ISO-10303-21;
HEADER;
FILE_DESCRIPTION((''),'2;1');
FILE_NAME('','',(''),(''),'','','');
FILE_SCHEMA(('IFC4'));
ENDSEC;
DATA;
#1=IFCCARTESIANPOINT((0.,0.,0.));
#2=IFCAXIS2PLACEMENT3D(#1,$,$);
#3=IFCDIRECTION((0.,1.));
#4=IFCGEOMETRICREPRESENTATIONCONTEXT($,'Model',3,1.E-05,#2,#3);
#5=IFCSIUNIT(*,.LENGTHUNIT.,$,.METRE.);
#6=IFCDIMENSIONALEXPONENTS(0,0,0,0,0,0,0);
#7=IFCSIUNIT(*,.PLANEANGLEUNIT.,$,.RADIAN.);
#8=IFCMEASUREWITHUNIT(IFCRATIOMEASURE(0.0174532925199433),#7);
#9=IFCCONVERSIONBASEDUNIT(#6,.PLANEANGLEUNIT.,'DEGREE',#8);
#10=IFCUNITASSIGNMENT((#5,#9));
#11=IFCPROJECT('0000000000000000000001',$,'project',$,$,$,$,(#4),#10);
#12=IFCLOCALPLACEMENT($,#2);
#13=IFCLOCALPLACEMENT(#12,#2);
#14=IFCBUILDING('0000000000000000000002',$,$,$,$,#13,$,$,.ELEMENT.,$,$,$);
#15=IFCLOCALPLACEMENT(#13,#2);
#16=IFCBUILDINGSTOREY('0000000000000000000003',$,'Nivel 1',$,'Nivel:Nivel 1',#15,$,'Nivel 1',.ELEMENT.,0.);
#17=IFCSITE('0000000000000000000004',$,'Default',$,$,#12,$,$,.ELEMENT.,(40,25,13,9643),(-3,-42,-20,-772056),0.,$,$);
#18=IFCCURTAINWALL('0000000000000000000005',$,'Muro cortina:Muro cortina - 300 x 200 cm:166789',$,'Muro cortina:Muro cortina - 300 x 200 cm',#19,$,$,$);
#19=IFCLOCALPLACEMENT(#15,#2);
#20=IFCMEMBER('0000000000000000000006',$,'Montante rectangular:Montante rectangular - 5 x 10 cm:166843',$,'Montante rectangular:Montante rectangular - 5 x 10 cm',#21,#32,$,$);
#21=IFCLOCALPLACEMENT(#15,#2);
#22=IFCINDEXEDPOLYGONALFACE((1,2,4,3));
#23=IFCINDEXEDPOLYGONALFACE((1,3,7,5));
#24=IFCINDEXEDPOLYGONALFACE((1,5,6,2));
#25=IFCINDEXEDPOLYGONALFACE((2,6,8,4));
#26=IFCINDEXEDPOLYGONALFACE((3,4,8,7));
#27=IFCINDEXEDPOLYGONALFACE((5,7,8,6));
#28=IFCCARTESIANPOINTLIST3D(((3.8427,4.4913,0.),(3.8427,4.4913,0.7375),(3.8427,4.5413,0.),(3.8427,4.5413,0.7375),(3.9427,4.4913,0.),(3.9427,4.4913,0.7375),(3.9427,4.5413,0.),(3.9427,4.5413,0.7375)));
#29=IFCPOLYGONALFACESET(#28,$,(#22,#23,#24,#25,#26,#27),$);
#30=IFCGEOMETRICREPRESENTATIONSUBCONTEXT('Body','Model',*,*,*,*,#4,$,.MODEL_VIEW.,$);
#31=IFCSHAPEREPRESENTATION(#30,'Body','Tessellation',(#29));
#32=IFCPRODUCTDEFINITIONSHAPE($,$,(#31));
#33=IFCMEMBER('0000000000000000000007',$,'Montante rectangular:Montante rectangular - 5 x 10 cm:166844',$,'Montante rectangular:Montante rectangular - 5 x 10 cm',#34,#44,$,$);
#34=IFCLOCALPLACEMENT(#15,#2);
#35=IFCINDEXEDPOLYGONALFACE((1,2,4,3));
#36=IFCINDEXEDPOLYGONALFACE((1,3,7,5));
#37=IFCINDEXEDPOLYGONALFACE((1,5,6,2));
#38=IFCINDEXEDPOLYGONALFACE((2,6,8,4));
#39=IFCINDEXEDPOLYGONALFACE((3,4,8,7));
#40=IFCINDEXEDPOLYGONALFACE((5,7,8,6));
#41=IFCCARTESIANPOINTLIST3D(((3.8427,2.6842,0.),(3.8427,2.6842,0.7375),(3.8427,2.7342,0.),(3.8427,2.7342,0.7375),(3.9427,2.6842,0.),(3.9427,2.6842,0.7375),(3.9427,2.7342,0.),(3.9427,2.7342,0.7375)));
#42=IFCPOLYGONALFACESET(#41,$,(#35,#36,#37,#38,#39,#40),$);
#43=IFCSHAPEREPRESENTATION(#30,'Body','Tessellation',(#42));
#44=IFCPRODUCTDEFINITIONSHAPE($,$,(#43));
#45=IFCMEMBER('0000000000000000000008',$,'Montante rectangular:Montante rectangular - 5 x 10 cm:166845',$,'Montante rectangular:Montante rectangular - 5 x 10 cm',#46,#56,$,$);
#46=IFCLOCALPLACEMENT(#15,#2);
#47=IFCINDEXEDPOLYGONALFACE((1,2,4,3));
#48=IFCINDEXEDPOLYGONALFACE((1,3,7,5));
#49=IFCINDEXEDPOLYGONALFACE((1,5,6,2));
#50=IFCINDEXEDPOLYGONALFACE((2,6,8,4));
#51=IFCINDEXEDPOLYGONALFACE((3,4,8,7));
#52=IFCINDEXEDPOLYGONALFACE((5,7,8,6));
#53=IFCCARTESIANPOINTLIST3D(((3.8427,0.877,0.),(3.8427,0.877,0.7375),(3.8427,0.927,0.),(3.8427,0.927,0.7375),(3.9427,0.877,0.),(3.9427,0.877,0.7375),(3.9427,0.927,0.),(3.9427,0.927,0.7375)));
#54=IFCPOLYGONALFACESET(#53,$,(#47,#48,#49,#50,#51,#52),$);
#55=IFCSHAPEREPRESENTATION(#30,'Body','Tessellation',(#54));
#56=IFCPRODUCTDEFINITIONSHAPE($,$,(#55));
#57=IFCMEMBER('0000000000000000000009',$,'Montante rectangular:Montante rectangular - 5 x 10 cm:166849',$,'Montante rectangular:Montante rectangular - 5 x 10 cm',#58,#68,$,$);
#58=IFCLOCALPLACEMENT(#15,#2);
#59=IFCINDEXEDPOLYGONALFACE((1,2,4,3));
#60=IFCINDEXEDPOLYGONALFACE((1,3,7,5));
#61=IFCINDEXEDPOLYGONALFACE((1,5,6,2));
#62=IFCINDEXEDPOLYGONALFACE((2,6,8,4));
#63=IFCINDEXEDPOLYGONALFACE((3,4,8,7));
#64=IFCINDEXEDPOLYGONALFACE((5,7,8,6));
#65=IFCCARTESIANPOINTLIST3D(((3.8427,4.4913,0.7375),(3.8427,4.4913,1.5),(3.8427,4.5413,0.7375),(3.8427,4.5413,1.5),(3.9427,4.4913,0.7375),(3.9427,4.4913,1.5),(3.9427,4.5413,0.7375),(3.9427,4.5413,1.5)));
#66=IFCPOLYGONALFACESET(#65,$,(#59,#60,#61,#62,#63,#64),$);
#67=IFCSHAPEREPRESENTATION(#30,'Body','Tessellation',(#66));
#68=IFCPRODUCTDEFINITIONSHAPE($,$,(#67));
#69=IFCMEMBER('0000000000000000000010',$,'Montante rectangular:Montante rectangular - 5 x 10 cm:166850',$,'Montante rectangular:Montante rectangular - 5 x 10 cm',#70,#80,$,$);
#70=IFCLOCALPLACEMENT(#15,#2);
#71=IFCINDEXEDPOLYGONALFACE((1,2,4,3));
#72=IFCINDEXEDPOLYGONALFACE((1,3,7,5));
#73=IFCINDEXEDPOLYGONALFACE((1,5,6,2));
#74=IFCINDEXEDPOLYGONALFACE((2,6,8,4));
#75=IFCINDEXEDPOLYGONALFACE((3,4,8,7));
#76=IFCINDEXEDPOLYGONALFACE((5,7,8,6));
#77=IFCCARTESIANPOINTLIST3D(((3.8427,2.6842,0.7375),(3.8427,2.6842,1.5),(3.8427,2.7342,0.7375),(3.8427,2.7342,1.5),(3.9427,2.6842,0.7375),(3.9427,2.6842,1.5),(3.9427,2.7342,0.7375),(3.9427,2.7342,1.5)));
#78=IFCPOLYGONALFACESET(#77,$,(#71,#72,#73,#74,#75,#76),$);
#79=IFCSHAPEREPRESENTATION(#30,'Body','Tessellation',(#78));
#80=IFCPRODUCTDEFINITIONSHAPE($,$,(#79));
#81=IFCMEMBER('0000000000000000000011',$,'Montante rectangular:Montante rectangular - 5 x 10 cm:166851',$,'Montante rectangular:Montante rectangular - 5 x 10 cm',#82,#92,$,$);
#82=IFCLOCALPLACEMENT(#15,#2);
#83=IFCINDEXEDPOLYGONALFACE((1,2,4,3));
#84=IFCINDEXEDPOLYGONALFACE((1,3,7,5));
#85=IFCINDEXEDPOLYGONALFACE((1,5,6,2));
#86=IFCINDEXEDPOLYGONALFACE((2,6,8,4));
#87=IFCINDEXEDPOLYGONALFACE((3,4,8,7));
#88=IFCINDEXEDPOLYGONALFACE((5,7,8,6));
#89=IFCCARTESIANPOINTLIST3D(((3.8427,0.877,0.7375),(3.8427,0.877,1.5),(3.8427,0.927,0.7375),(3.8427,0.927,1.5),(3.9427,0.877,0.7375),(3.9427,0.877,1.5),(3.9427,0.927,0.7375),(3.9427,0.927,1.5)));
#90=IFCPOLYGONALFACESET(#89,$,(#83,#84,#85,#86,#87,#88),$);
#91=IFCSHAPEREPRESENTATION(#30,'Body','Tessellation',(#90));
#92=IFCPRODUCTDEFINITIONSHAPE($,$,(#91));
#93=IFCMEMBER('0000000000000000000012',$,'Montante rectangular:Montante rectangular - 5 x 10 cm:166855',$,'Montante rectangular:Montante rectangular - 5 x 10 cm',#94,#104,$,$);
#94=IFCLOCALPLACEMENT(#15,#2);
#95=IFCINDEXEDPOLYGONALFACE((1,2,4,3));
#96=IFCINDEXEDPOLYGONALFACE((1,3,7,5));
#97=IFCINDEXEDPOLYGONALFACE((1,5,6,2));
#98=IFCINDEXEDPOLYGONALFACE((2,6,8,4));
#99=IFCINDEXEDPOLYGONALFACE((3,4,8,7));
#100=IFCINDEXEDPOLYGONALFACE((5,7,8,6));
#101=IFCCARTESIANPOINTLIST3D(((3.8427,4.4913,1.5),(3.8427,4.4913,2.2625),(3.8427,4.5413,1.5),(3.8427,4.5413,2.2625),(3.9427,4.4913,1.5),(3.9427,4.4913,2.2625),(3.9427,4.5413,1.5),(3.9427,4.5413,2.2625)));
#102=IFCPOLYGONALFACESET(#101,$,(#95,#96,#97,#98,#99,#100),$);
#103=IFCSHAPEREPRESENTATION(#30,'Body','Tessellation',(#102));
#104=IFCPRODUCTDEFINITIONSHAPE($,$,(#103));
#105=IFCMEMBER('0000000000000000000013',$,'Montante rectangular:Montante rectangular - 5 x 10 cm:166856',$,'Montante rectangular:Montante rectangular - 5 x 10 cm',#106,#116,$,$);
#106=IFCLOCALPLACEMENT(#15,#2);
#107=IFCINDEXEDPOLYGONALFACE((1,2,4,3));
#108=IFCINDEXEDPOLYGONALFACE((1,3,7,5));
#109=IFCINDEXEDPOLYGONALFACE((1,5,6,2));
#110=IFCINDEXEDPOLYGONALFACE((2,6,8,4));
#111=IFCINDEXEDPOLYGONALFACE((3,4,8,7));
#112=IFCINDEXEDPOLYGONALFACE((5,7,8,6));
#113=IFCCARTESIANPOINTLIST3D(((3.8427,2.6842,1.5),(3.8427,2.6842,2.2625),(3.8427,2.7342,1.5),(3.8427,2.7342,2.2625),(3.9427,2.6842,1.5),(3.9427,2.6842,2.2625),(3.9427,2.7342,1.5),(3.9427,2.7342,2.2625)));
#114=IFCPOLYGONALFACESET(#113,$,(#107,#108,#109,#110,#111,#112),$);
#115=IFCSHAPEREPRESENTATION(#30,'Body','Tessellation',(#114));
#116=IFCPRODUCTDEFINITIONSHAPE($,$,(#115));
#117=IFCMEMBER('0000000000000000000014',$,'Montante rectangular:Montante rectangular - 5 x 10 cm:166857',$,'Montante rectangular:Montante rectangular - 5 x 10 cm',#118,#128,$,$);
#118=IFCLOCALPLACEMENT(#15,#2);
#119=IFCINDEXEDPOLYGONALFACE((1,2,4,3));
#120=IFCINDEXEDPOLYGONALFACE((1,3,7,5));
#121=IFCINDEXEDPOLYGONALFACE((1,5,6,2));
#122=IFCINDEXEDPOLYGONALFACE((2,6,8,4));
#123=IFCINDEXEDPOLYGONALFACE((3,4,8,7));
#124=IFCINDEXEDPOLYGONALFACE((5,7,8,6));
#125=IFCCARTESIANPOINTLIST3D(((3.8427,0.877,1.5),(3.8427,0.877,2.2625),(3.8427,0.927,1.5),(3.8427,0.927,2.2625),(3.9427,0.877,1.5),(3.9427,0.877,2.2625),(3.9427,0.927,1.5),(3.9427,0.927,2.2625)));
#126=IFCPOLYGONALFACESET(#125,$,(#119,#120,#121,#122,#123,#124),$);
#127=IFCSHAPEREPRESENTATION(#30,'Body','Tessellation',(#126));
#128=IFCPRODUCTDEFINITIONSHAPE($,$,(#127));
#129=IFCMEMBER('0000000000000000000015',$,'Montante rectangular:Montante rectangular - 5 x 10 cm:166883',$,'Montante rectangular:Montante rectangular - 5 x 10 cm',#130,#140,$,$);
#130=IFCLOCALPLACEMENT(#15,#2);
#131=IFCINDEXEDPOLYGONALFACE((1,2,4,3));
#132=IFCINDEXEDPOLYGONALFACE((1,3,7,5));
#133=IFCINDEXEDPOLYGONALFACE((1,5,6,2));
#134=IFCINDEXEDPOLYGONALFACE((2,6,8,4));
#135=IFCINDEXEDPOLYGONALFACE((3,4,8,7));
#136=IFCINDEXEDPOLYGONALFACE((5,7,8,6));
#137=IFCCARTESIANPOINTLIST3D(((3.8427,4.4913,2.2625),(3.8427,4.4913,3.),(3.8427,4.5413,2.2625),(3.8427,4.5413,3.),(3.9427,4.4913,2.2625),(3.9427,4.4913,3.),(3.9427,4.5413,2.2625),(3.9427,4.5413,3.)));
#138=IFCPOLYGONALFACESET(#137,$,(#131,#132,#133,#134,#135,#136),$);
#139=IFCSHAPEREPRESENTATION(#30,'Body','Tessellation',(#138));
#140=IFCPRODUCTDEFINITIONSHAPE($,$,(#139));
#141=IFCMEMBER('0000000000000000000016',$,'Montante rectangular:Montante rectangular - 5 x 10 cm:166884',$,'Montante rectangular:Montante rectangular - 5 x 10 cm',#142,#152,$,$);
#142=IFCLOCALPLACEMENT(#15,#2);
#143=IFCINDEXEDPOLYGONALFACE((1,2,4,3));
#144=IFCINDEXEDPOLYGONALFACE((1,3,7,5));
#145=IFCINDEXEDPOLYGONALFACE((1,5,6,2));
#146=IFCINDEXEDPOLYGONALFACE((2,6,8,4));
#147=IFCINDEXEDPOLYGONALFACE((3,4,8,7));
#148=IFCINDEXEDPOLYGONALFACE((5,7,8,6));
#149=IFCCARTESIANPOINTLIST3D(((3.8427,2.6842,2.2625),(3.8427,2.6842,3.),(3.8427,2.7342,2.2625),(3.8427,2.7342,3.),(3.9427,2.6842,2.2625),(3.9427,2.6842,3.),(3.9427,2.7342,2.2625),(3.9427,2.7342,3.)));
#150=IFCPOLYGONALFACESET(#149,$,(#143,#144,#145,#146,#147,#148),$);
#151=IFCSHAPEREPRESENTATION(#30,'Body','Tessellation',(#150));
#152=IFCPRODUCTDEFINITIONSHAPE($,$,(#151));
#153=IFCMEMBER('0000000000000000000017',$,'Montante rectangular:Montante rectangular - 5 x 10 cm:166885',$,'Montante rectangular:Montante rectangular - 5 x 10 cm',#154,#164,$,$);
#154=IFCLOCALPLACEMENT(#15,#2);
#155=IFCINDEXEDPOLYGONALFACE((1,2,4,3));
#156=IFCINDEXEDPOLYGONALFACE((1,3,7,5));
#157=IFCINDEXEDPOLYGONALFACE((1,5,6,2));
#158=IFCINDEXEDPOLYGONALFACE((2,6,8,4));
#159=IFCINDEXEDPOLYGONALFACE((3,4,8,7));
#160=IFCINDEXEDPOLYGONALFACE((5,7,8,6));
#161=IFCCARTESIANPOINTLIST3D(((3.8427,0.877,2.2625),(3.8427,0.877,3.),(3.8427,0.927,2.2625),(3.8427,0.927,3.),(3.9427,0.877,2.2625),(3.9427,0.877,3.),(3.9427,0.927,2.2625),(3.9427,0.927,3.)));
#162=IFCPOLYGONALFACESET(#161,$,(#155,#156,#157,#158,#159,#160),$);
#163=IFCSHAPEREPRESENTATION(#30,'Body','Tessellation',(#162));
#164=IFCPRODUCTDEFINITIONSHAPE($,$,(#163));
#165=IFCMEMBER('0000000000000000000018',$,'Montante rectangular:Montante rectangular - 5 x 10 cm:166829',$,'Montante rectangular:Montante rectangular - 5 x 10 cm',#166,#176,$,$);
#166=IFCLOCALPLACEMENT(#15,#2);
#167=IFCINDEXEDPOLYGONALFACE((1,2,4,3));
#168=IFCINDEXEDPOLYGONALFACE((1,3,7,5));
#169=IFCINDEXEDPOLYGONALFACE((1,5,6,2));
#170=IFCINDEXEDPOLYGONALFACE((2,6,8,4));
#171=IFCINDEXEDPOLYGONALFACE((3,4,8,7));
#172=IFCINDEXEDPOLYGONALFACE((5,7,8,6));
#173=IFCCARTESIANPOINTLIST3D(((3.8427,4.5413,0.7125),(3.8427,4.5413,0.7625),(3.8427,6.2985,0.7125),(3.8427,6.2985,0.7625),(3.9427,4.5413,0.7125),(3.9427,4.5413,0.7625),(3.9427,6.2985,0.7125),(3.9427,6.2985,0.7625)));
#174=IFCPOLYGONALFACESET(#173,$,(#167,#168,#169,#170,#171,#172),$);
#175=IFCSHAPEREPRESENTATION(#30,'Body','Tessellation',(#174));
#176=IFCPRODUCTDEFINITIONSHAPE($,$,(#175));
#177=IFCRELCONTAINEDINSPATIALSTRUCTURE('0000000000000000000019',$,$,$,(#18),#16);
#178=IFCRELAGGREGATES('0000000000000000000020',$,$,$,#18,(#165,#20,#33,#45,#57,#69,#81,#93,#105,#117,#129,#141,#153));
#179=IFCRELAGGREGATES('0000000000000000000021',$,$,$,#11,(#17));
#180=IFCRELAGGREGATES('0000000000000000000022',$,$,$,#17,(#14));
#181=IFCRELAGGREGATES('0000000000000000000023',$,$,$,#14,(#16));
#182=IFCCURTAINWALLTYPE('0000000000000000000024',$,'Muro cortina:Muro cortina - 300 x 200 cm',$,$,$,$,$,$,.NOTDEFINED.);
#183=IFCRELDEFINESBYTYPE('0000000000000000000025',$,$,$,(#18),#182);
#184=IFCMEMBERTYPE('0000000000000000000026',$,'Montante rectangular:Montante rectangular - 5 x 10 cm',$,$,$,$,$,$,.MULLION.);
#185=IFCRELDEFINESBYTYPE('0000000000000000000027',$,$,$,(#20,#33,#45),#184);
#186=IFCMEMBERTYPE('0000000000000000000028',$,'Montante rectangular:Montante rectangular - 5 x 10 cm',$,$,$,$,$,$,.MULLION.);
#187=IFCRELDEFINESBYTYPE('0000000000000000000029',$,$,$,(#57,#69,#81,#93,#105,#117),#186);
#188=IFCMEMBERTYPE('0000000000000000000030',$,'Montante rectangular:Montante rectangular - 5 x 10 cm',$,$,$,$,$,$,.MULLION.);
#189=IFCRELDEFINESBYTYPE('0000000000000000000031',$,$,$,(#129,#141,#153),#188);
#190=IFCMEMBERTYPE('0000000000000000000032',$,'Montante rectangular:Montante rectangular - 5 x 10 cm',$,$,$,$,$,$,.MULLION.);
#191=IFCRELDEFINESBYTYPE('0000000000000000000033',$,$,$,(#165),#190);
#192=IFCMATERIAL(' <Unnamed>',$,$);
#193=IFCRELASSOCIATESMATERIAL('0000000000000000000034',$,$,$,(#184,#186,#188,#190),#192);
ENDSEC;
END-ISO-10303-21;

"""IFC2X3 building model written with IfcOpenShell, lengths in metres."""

from ifc_helpers import new_model, entity, si_unit, converted_unit, direction, frame, origin, origin_2d_with_axis, place, context, subcontext, project, spatial, rectangle, extrude, source, transform, mapped, material, type_object, type_shapes, element, aggregate, save


model = new_model("IFC2X3")

# Units and contexts
model_context = context("Model", 3, precision=1e-05, world=origin(), true_north=direction((0.0, 1.0)))
body_context = subcontext(model_context, "Body", "Model", "MODEL_VIEW")
ifc_project = project(units=[si_unit("LENGTHUNIT", "METRE"), converted_unit("PLANEANGLEUNIT", "DEGREE", entity("IfcRatioMeasure", 0.0174532925199433), si_unit("PLANEANGLEUNIT", "RADIAN"), dimensions=[0, 0, 0, 0, 0, 0, 0])], contexts=[model_context])

# Site, building, storey
site_placement = place(None, origin())
site = spatial("IfcSite", under=ifc_project, at=site_placement, Name="Default", CompositionType="ELEMENT", RefLatitude=(40, 25, 13, 9643), RefLongitude=(-3, -42, -20, -772056), RefElevation=0.0)
building_placement = place(site_placement, origin())
building = spatial("IfcBuilding", under=site, at=building_placement, CompositionType="ELEMENT")
storey_placement = place(building_placement, origin())
storey = spatial("IfcBuildingStorey", under=building, at=storey_placement, Name="Nivel 1", ObjectType="Nivel:Nivel 1", LongName="Nivel 1", CompositionType="ELEMENT", Elevation=0.0)

# Curtain wall, members
curtain_wall_type = type_object("IfcCurtainWallType", Name="Muro cortina:Muro cortina - 300 x 200 cm", PredefinedType="NOTDEFINED")
curtain_wall_placement = place(storey_placement, origin())
curtain_wall = element("IfcCurtainWall", 1, at=curtain_wall_placement, inside=storey, type_object=curtain_wall_type, Name="Muro cortina:Muro cortina - 300 x 200 cm:166789", ObjectType="Muro cortina:Muro cortina - 300 x 200 cm")
ifc_material_1 = material(Name=" <Unnamed>")
member_type_1 = type_object("IfcMemberType", Name="Montante rectangular:Montante rectangular - 5 x 10 cm", PredefinedType="MULLION", material=ifc_material_1)
shared_shape_1 = source(origin(), body_context, "Body", "SweptSolid", [
    extrude(rectangle(XDim=0.1, YDim=0.05, at=origin_2d_with_axis()), frame((0.0, 0.0, -0.7375), z_axis=(0.0, 0.0, 1.0), x_axis=(0.0, -1.0, 0.0)), (0.0, 0.0, 1.0), 0.7375),
])
type_shapes(member_type_1, [shared_shape_1])
member_1_placement = place(storey_placement, frame((3.8927, 4.5163, 0.0), z_axis=(0.0, 0.0, -1.0), x_axis=(0.0, -1.0, 0.0)))
member_1 = element("IfcMember", 2, at=member_1_placement, type_object=member_type_1, Name="Montante rectangular:Montante rectangular - 5 x 10 cm:166843", ObjectType="Montante rectangular:Montante rectangular - 5 x 10 cm", context=body_context, shape_type="MappedRepresentation", body=[
    mapped(shared_shape_1, transform((0.0, 0.0, 0.0), scale=1.0)),
])
member_2_placement = place(storey_placement, frame((3.8927, 2.7092, 0.0), z_axis=(0.0, 0.0, -1.0), x_axis=(0.0, -1.0, 0.0)))
member_2 = element("IfcMember", 3, at=member_2_placement, type_object=member_type_1, Name="Montante rectangular:Montante rectangular - 5 x 10 cm:166844", ObjectType="Montante rectangular:Montante rectangular - 5 x 10 cm", context=body_context, shape_type="MappedRepresentation", body=[
    mapped(shared_shape_1, transform((0.0, 0.0, 0.0), scale=1.0)),
])
member_3_placement = place(storey_placement, frame((3.8927, 0.902, 0.0), z_axis=(0.0, 0.0, -1.0), x_axis=(0.0, -1.0, 0.0)))
member_3 = element("IfcMember", 4, at=member_3_placement, type_object=member_type_1, Name="Montante rectangular:Montante rectangular - 5 x 10 cm:166845", ObjectType="Montante rectangular:Montante rectangular - 5 x 10 cm", context=body_context, shape_type="MappedRepresentation", body=[
    mapped(shared_shape_1, transform((0.0, 0.0, 0.0), scale=1.0)),
])
member_type_2 = type_object("IfcMemberType", Name="Montante rectangular:Montante rectangular - 5 x 10 cm", PredefinedType="MULLION", material=ifc_material_1)
shared_shape_2 = source(origin(), body_context, "Body", "SweptSolid", [
    extrude(rectangle(XDim=0.1, YDim=0.05, at=origin_2d_with_axis()), frame((0.0, 0.0, -0.7625), z_axis=(0.0, 0.0, 1.0), x_axis=(0.0, -1.0, 0.0)), (0.0, 0.0, 1.0), 0.7625),
])
type_shapes(member_type_2, [shared_shape_2])
member_4_placement = place(storey_placement, frame((3.8927, 4.5163, 0.7375), z_axis=(0.0, 0.0, -1.0), x_axis=(0.0, -1.0, 0.0)))
member_4 = element("IfcMember", 5, at=member_4_placement, type_object=member_type_2, Name="Montante rectangular:Montante rectangular - 5 x 10 cm:166849", ObjectType="Montante rectangular:Montante rectangular - 5 x 10 cm", context=body_context, shape_type="MappedRepresentation", body=[
    mapped(shared_shape_2, transform((0.0, 0.0, 0.0), scale=1.0)),
])
member_5_placement = place(storey_placement, frame((3.8927, 2.7092, 0.7375), z_axis=(0.0, 0.0, -1.0), x_axis=(0.0, -1.0, 0.0)))
member_5 = element("IfcMember", 6, at=member_5_placement, type_object=member_type_2, Name="Montante rectangular:Montante rectangular - 5 x 10 cm:166850", ObjectType="Montante rectangular:Montante rectangular - 5 x 10 cm", context=body_context, shape_type="MappedRepresentation", body=[
    mapped(shared_shape_2, transform((0.0, 0.0, 0.0), scale=1.0)),
])
member_6_placement = place(storey_placement, frame((3.8927, 0.902, 0.7375), z_axis=(0.0, 0.0, -1.0), x_axis=(0.0, -1.0, 0.0)))
member_6 = element("IfcMember", 7, at=member_6_placement, type_object=member_type_2, Name="Montante rectangular:Montante rectangular - 5 x 10 cm:166851", ObjectType="Montante rectangular:Montante rectangular - 5 x 10 cm", context=body_context, shape_type="MappedRepresentation", body=[
    mapped(shared_shape_2, transform((0.0, 0.0, 0.0), scale=1.0)),
])
member_7_placement = place(storey_placement, frame((3.8927, 4.5163, 1.5), z_axis=(0.0, 0.0, -1.0), x_axis=(0.0, -1.0, 0.0)))
member_7 = element("IfcMember", 8, at=member_7_placement, type_object=member_type_2, Name="Montante rectangular:Montante rectangular - 5 x 10 cm:166855", ObjectType="Montante rectangular:Montante rectangular - 5 x 10 cm", context=body_context, shape_type="MappedRepresentation", body=[
    mapped(shared_shape_2, transform((0.0, 0.0, 0.0), scale=1.0)),
])
member_8_placement = place(storey_placement, frame((3.8927, 2.7092, 1.5), z_axis=(0.0, 0.0, -1.0), x_axis=(0.0, -1.0, 0.0)))
member_8 = element("IfcMember", 9, at=member_8_placement, type_object=member_type_2, Name="Montante rectangular:Montante rectangular - 5 x 10 cm:166856", ObjectType="Montante rectangular:Montante rectangular - 5 x 10 cm", context=body_context, shape_type="MappedRepresentation", body=[
    mapped(shared_shape_2, transform((0.0, 0.0, 0.0), scale=1.0)),
])
member_9_placement = place(storey_placement, frame((3.8927, 0.902, 1.5), z_axis=(0.0, 0.0, -1.0), x_axis=(0.0, -1.0, 0.0)))
member_9 = element("IfcMember", 10, at=member_9_placement, type_object=member_type_2, Name="Montante rectangular:Montante rectangular - 5 x 10 cm:166857", ObjectType="Montante rectangular:Montante rectangular - 5 x 10 cm", context=body_context, shape_type="MappedRepresentation", body=[
    mapped(shared_shape_2, transform((0.0, 0.0, 0.0), scale=1.0)),
])
member_type_3 = type_object("IfcMemberType", Name="Montante rectangular:Montante rectangular - 5 x 10 cm", PredefinedType="MULLION", material=ifc_material_1)
shared_shape_3 = source(origin(), body_context, "Body", "SweptSolid", [
    extrude(rectangle(XDim=0.1, YDim=0.05, at=origin_2d_with_axis()), frame((0.0, 0.0, -0.7375), z_axis=(0.0, 0.0, 1.0), x_axis=(0.0, -1.0, 0.0)), (0.0, 0.0, 1.0), 0.7375),
])
type_shapes(member_type_3, [shared_shape_3])
member_10_placement = place(storey_placement, frame((3.8927, 4.5163, 2.2625), z_axis=(0.0, 0.0, -1.0), x_axis=(0.0, -1.0, 0.0)))
member_10 = element("IfcMember", 11, at=member_10_placement, type_object=member_type_3, Name="Montante rectangular:Montante rectangular - 5 x 10 cm:166883", ObjectType="Montante rectangular:Montante rectangular - 5 x 10 cm", context=body_context, shape_type="MappedRepresentation", body=[
    mapped(shared_shape_3, transform((0.0, 0.0, 0.0), scale=1.0)),
])
member_11_placement = place(storey_placement, frame((3.8927, 2.7092, 2.2625), z_axis=(0.0, 0.0, -1.0), x_axis=(0.0, -1.0, 0.0)))
member_11 = element("IfcMember", 12, at=member_11_placement, type_object=member_type_3, Name="Montante rectangular:Montante rectangular - 5 x 10 cm:166884", ObjectType="Montante rectangular:Montante rectangular - 5 x 10 cm", context=body_context, shape_type="MappedRepresentation", body=[
    mapped(shared_shape_3, transform((0.0, 0.0, 0.0), scale=1.0)),
])
member_12_placement = place(storey_placement, frame((3.8927, 0.902, 2.2625), z_axis=(0.0, 0.0, -1.0), x_axis=(0.0, -1.0, 0.0)))
member_12 = element("IfcMember", 13, at=member_12_placement, type_object=member_type_3, Name="Montante rectangular:Montante rectangular - 5 x 10 cm:166885", ObjectType="Montante rectangular:Montante rectangular - 5 x 10 cm", context=body_context, shape_type="MappedRepresentation", body=[
    mapped(shared_shape_3, transform((0.0, 0.0, 0.0), scale=1.0)),
])
member_type_4 = type_object("IfcMemberType", Name="Montante rectangular:Montante rectangular - 5 x 10 cm", PredefinedType="MULLION", material=ifc_material_1)
shared_shape_4 = source(origin(), body_context, "Body", "SweptSolid", [
    extrude(rectangle(XDim=0.1, YDim=0.05, at=origin_2d_with_axis()), frame((0.0, 0.0, -1.7571), z_axis=(0.0, 0.0, 1.0), x_axis=(0.0, -1.0, 0.0)), (0.0, 0.0, 1.0), 1.7571),
])
type_shapes(member_type_4, [shared_shape_4])
member_13_placement = place(storey_placement, frame((3.8927, 4.5413, 0.7375), z_axis=(0.0, -1.0, 0.0), x_axis=(0.0, 0.0, 1.0)))
member_13 = element("IfcMember", 14, at=member_13_placement, type_object=member_type_4, Name="Montante rectangular:Montante rectangular - 5 x 10 cm:166829", ObjectType="Montante rectangular:Montante rectangular - 5 x 10 cm", context=body_context, shape_type="MappedRepresentation", body=[
    mapped(shared_shape_4, transform((0.0, 0.0, 0.0), scale=1.0)),
])
aggregate(curtain_wall, [member_13, member_1, member_2, member_3, member_4, member_5, member_6, member_7, member_8, member_9, member_10, member_11, member_12])

save(model, "model.ifc")
